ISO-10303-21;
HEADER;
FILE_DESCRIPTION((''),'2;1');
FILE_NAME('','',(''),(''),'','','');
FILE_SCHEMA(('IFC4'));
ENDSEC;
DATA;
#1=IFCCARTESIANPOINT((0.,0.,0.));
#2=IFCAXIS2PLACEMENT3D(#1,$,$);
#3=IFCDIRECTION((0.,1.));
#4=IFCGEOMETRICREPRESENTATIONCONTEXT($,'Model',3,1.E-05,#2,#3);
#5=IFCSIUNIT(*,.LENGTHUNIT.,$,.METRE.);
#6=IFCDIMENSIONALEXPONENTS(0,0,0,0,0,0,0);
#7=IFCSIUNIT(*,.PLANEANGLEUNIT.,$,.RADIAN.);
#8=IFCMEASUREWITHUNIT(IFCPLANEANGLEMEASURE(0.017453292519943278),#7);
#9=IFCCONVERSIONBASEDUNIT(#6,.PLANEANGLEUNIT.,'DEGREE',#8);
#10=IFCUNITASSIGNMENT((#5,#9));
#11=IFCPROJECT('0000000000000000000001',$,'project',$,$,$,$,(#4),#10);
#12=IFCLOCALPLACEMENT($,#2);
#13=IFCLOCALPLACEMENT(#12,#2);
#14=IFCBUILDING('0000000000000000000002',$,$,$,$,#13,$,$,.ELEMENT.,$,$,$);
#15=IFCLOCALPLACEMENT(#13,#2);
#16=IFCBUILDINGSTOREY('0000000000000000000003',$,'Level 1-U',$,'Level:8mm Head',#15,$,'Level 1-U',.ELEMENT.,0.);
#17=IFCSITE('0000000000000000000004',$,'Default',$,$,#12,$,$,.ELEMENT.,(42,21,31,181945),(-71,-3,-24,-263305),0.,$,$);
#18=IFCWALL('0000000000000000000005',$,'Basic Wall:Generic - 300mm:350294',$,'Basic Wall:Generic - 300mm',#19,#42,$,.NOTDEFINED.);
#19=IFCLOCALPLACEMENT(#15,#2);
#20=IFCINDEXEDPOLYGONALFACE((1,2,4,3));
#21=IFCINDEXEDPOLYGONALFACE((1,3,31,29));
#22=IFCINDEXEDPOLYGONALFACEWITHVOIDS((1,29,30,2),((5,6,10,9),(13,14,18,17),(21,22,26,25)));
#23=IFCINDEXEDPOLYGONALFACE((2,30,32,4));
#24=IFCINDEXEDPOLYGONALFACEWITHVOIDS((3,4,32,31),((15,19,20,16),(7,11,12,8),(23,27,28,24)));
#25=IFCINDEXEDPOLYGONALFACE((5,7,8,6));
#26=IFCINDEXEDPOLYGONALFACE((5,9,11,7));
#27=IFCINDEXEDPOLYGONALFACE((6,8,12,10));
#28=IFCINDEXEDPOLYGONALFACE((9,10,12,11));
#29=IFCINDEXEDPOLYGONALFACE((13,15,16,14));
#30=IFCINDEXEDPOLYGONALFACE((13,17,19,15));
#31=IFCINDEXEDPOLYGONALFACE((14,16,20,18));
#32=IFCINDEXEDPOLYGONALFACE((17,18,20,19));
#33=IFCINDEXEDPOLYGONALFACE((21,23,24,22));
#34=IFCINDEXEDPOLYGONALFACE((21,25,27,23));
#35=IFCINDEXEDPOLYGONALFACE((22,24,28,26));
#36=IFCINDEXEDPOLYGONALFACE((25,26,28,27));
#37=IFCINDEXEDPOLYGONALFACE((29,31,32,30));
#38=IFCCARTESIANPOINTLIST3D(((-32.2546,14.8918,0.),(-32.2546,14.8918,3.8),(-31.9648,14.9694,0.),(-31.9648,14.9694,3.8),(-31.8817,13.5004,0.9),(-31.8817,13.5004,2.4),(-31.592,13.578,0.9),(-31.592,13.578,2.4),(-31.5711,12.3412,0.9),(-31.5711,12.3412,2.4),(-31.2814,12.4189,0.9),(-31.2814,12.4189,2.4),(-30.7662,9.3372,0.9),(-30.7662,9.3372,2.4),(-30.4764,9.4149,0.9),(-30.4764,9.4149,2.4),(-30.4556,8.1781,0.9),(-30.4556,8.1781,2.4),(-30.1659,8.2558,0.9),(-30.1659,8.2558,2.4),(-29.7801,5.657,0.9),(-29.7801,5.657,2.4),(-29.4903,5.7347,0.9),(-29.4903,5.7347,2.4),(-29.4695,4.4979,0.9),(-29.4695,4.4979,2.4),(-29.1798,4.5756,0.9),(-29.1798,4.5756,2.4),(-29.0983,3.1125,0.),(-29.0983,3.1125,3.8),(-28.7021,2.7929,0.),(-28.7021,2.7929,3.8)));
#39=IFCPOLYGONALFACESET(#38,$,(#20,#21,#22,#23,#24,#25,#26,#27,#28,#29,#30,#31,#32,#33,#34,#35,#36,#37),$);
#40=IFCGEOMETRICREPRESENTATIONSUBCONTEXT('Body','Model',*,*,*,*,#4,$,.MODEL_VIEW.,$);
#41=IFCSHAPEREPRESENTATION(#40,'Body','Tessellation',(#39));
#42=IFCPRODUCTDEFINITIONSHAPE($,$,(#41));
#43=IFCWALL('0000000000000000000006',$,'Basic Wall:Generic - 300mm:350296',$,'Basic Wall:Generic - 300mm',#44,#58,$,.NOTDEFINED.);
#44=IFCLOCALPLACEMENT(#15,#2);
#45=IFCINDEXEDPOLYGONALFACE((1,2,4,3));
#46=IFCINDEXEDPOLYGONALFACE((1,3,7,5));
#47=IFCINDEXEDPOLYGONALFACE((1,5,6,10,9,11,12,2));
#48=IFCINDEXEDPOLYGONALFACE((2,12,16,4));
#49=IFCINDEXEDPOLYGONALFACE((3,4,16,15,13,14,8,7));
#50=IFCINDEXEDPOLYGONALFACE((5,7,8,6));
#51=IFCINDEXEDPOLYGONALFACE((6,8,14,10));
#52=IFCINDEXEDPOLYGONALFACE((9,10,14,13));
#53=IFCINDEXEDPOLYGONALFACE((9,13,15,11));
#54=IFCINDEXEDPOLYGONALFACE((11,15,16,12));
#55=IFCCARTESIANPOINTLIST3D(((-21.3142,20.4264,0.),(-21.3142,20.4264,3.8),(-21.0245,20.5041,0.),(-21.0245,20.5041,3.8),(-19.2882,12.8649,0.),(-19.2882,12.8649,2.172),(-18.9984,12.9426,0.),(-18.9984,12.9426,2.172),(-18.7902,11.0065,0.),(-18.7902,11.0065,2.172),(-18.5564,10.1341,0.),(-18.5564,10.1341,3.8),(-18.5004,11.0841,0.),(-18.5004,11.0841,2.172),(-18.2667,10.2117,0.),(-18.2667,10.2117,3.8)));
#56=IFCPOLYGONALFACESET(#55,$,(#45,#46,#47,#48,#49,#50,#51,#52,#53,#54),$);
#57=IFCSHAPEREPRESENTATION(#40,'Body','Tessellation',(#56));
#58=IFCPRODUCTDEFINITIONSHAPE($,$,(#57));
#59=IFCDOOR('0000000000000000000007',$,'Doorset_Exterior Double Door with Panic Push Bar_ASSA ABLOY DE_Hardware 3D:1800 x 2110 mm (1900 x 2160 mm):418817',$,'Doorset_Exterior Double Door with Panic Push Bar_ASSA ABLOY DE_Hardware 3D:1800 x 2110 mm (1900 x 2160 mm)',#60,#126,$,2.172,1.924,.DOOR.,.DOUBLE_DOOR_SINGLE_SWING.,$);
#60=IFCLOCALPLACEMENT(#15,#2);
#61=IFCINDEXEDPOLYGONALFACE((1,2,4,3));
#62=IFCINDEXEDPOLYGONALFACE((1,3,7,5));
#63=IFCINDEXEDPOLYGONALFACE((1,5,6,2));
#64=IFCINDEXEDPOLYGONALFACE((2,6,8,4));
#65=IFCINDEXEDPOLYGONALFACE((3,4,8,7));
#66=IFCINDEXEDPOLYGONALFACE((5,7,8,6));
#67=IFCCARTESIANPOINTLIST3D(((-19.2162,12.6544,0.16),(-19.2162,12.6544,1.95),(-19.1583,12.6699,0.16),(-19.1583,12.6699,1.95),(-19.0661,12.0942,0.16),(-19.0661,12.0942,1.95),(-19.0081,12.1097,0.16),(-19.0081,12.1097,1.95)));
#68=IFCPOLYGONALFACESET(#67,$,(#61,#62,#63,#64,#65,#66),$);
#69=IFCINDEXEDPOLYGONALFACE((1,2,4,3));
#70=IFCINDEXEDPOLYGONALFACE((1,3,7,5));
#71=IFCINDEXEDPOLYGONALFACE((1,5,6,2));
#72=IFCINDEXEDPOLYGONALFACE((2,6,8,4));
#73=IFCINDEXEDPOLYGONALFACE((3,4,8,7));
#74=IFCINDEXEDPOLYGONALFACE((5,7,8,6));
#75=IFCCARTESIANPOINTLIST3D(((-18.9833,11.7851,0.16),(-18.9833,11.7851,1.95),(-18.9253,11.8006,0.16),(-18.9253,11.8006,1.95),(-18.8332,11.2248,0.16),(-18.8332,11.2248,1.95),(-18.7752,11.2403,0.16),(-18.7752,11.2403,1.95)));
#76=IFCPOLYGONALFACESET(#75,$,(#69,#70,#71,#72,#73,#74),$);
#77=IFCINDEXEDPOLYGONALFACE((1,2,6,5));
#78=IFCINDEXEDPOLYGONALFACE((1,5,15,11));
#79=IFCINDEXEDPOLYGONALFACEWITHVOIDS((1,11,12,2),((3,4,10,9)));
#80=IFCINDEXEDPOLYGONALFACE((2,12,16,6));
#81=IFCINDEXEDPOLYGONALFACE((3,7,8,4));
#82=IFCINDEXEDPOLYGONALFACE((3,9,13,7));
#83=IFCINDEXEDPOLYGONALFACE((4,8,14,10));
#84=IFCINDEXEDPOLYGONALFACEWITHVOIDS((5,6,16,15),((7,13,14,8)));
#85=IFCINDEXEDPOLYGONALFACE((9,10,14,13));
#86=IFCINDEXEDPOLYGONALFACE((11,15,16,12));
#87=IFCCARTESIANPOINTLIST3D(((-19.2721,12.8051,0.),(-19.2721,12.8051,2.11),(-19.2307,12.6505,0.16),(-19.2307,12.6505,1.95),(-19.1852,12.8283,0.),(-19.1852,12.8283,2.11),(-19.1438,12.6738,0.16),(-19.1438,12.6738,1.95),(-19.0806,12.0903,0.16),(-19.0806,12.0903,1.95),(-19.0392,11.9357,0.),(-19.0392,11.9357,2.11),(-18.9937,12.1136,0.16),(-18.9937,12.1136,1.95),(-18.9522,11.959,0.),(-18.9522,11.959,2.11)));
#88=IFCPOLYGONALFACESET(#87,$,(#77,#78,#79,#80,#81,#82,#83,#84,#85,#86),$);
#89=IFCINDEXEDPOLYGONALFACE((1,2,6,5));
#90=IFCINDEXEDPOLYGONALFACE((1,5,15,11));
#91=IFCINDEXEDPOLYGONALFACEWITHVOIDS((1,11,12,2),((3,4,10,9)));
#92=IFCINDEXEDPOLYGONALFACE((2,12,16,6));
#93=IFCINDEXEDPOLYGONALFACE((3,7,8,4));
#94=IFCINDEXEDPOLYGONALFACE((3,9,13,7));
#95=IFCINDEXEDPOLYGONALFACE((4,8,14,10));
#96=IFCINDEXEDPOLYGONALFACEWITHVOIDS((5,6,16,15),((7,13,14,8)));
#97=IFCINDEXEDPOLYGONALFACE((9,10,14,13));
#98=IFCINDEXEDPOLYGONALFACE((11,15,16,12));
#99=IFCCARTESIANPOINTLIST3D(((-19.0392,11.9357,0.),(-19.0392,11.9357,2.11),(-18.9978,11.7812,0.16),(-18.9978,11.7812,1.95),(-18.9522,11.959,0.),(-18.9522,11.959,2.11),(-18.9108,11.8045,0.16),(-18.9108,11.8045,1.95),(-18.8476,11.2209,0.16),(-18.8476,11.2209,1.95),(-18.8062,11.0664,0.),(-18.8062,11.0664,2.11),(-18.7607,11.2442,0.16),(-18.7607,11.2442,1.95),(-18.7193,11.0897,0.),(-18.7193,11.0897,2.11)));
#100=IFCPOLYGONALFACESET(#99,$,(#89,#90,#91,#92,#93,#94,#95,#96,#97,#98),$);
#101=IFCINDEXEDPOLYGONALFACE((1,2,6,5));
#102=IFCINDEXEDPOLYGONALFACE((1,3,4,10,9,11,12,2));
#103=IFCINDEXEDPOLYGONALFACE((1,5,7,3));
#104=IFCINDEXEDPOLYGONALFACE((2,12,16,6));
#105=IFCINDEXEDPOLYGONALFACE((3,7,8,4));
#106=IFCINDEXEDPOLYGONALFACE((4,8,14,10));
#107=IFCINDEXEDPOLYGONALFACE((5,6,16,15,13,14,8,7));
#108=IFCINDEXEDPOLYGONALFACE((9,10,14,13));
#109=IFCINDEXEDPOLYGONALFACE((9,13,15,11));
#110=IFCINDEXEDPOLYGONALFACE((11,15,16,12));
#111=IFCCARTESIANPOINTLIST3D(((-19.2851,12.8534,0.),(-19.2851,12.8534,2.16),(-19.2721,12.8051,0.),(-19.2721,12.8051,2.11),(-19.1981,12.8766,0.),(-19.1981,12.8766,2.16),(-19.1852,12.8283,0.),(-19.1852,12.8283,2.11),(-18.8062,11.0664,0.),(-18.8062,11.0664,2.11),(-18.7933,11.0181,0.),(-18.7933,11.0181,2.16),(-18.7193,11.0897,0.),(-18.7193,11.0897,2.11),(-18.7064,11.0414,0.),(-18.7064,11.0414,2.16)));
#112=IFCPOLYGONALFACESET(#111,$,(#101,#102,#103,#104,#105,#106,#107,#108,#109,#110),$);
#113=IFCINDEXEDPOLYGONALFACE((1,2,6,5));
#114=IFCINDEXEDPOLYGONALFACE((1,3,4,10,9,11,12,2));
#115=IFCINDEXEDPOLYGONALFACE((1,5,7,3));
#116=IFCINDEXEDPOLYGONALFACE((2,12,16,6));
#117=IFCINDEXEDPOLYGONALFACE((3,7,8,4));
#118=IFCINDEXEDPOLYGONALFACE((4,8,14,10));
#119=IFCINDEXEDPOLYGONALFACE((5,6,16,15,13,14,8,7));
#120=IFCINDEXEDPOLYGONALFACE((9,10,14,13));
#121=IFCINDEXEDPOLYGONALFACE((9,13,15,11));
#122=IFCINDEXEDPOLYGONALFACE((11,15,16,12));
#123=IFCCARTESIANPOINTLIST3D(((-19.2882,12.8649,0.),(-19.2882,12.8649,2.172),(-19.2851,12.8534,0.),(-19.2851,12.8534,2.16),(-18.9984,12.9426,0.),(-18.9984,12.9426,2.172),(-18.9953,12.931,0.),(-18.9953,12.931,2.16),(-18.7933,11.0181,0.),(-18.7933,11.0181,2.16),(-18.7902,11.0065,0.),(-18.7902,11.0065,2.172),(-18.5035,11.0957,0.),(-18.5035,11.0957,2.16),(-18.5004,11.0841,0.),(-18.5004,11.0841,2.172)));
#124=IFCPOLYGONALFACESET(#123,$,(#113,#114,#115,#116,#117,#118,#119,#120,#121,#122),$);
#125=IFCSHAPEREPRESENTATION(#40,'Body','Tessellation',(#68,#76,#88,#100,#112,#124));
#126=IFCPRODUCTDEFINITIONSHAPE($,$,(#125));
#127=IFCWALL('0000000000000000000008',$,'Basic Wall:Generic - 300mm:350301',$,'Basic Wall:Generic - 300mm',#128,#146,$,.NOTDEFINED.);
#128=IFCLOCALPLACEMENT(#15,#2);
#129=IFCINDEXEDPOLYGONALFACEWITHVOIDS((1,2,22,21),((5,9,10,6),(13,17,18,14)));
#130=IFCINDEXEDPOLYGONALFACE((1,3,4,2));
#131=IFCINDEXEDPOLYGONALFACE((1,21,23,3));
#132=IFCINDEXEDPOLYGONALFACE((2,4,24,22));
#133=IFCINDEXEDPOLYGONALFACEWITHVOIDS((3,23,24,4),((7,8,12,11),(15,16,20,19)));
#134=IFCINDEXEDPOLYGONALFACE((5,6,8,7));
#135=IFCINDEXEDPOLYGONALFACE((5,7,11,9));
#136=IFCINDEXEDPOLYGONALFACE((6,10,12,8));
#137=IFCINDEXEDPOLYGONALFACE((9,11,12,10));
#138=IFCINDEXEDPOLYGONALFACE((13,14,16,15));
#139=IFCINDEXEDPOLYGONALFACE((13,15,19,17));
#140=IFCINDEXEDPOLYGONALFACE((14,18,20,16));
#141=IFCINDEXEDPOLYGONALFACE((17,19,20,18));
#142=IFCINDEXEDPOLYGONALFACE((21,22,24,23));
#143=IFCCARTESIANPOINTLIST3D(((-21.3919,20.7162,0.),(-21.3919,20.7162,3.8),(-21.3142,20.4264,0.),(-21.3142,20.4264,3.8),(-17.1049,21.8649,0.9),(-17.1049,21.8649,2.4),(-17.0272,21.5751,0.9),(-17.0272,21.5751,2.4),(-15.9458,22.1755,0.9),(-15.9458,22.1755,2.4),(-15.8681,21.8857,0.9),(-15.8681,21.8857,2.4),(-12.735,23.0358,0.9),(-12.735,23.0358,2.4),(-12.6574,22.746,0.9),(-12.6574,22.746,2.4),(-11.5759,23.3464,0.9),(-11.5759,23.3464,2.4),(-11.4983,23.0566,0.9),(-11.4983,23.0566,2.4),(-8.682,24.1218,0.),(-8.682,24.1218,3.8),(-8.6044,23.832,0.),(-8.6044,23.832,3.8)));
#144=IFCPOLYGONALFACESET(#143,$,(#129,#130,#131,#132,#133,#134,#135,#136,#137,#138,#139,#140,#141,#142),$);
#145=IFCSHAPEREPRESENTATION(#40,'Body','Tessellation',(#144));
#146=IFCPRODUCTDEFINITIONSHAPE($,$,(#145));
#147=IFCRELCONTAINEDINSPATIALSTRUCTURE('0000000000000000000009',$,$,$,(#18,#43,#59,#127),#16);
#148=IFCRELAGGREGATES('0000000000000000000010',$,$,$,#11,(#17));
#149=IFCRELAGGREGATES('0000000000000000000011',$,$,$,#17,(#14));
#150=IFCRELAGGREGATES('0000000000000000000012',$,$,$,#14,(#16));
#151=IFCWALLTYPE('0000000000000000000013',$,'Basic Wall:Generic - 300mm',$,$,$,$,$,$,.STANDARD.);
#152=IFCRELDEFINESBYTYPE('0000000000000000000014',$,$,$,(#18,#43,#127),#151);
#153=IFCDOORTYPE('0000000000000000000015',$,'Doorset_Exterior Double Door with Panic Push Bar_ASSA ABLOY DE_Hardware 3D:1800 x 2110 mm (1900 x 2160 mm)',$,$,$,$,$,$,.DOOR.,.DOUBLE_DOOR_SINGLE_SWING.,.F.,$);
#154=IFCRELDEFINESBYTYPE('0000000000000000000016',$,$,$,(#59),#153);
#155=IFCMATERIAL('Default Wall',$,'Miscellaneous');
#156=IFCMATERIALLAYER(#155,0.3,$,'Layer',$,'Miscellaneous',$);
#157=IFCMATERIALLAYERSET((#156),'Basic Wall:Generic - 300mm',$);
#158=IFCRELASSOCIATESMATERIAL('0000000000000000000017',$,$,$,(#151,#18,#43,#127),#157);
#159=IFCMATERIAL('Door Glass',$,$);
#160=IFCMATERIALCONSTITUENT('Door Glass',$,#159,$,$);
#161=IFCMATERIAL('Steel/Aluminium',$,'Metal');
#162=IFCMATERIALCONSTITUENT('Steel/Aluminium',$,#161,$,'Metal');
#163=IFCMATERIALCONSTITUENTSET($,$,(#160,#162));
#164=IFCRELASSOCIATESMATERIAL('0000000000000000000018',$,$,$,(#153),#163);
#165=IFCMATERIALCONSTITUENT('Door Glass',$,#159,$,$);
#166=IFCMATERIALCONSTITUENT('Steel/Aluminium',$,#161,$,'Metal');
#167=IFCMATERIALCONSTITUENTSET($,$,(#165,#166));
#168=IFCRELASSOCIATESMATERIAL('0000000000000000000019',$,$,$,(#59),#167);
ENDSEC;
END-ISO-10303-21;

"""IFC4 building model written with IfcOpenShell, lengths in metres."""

from ifc_helpers import new_model, entity, si_unit, converted_unit, direction, frame, frame_2d, origin, origin_2d_with_axis, place, context, subcontext, project, spatial, polyline, rectangle, outline, extrude, source, transform, mapped, material, layer, layer_set, layer_usage, constituent, constituent_set, type_object, type_shapes, element, fill, save


model = new_model("IFC4")

# Units and contexts
model_context = context("Model", 3, precision=1e-05, world=origin(), true_north=direction((0.0, 1.0)))
body_context = subcontext(model_context, "Body", "Model", "MODEL_VIEW")
ifc_project = project(units=[si_unit("LENGTHUNIT", "METRE"), converted_unit("PLANEANGLEUNIT", "DEGREE", entity("IfcPlaneAngleMeasure", 0.017453292519943278), si_unit("PLANEANGLEUNIT", "RADIAN"), dimensions=[0, 0, 0, 0, 0, 0, 0])], contexts=[model_context])

# Site, building, storey
site_placement = place(None, origin())
site = spatial("IfcSite", under=ifc_project, at=site_placement, Name="Default", CompositionType="ELEMENT", RefLatitude=(42, 21, 31, 181945), RefLongitude=(-71, -3, -24, -263305), RefElevation=0.0)
building_placement = place(site_placement, origin())
building = spatial("IfcBuilding", under=site, at=building_placement, CompositionType="ELEMENT")
storey_placement = place(building_placement, origin())
storey = spatial("IfcBuildingStorey", under=building, at=storey_placement, Name="Level 1-U", ObjectType="Level:8mm Head", LongName="Level 1-U", CompositionType="ELEMENT", Elevation=0.0)

# Wall, openings
ifc_material_1 = material(Name="Default Wall", Category="Miscellaneous")
ifc_layer_1 = layer(ifc_material_1, 0.3, Name="Layer", Category="Miscellaneous")
ifc_layer_set_1 = layer_set([ifc_layer_1], Name="Basic Wall:Generic - 300mm")
ifc_layer_usage_1 = layer_usage(ifc_layer_set_1, "AXIS2", "NEGATIVE", 0.15)
wall_type_1 = type_object("IfcWallType", Name="Basic Wall:Generic - 300mm", PredefinedType="STANDARD", material=ifc_layer_set_1)
wall_1_placement = place(storey_placement, frame((-32.1097, 14.9306, 0.0), z_axis=(0.0, 0.0, 1.0), x_axis=(0.258819, -0.965926, 0.0)))
wall_1 = element("IfcWall", 1, at=wall_1_placement, inside=storey, type_object=wall_type_1, material=ifc_layer_usage_1, Name="Basic Wall:Generic - 300mm:350294", ObjectType="Basic Wall:Generic - 300mm", PredefinedType="NOTDEFINED", context=body_context, shape_type="SweptSolid", body=[
    extrude(outline(polyline([(12.1948, -0.15), (12.606, 0.15), (12.097, 0.15), (0.0, 0.15), (0.0, -0.15), (12.1948, -0.15)])), origin(), (0.0, 0.0, 1.0), 3.8),
])
opening_1_placement = place(wall_1_placement, frame((10.7605, 0.15, 0.9)))
element("IfcOpeningElement", 2, at=opening_1_placement, cuts=wall_1, PredefinedType="OPENING", context=body_context, shape_type="SweptSolid", body=[
    extrude(rectangle(XDim=1.5, YDim=1.2, at=frame_2d((0.75, 0.6), x_axis=(-1.0, 0.0))), frame((0.0, 0.0, 0.0), z_axis=(0.0, -1.0, 0.0), x_axis=(0.0, 0.0, 1.0)), (0.0, 0.0, 1.0), 0.3),
])
opening_2_placement = place(wall_1_placement, frame((6.9505, 0.15, 0.9)))
element("IfcOpeningElement", 3, at=opening_2_placement, cuts=wall_1, PredefinedType="OPENING", context=body_context, shape_type="SweptSolid", body=[
    extrude(rectangle(XDim=1.5, YDim=1.2, at=frame_2d((0.75, 0.6), x_axis=(-1.0, 0.0))), frame((0.0, 0.0, 0.0), z_axis=(0.0, -1.0, 0.0), x_axis=(0.0, 0.0, 1.0)), (0.0, 0.0, 1.0), 0.3),
])
opening_3_placement = place(wall_1_placement, frame((2.6405, 0.15, 0.9)))
element("IfcOpeningElement", 4, at=opening_3_placement, cuts=wall_1, PredefinedType="OPENING", context=body_context, shape_type="SweptSolid", body=[
    extrude(rectangle(XDim=1.5, YDim=1.2, at=frame_2d((0.75, 0.6), x_axis=(-1.0, 0.0))), frame((0.0, 0.0, 0.0), z_axis=(0.0, -1.0, 0.0), x_axis=(0.0, 0.0, 1.0)), (0.0, 0.0, 1.0), 0.3),
])

# Wall, opening, door
wall_2_placement = place(storey_placement, frame((-18.4115, 10.1729, 0.0), z_axis=(0.0, 0.0, 1.0), x_axis=(-0.258819, 0.965926, 0.0)))
wall_2 = element("IfcWall", 5, at=wall_2_placement, inside=storey, type_object=wall_type_1, material=ifc_layer_usage_1, Name="Basic Wall:Generic - 300mm:350296", ObjectType="Basic Wall:Generic - 300mm", PredefinedType="NOTDEFINED", context=body_context, shape_type="SweptSolid", body=[
    extrude(rectangle(XDim=10.6554, YDim=0.3, at=frame_2d((5.3277, 0.0), x_axis=(-1.0, 0.0))), origin(), (0.0, 0.0, 1.0), 3.8),
])
opening_4_placement = place(wall_2_placement, frame((0.9032, -0.15, 0.0)))
opening_4 = element("IfcOpeningElement", 6, at=opening_4_placement, cuts=wall_2, PredefinedType="OPENING", context=body_context, shape_type="SweptSolid", body=[
    extrude(rectangle(XDim=2.172, YDim=1.924, at=frame_2d((1.086, 0.962), x_axis=(-1.0, 0.0))), frame((0.0, 0.0, 0.0), z_axis=(0.0, 1.0, 0.0), x_axis=(0.0, 0.0, 1.0)), (0.0, 0.0, 1.0), 0.3),
])
ifc_material_2 = material(Name="Door Glass")
ifc_constituent_1 = constituent(ifc_material_2, Name="Door Glass")
ifc_material_3 = material(Name="Steel/Aluminium", Category="Metal")
ifc_constituent_2 = constituent(ifc_material_3, Name="Steel/Aluminium", Category="Metal")
ifc_constituent_set_1 = constituent_set(constituents=[ifc_constituent_1, ifc_constituent_2])
ifc_constituent_3 = constituent(ifc_material_2, Name="Door Glass")
ifc_constituent_4 = constituent(ifc_material_3, Name="Steel/Aluminium", Category="Metal")
ifc_constituent_set_2 = constituent_set(constituents=[ifc_constituent_3, ifc_constituent_4])
door_type_1 = type_object("IfcDoorType", Name="Doorset_Exterior Double Door with Panic Push Bar_ASSA ABLOY DE_Hardware 3D:1800 x 2110 mm (1900 x 2160 mm)", OperationType="DOUBLE_DOOR_SINGLE_SWING", ParameterTakesPrecedence=False, PredefinedType="DOOR", material=ifc_constituent_set_2)
shared_shape_1 = source(origin(), body_context, "Body", "SweptSolid", [
    extrude(rectangle(XDim=0.58, YDim=0.06, at=frame_2d((0.0, 0.0), x_axis=(1.0, 0.0))), frame((1.412, 0.255, 0.16)), (0.0, 0.0, 1.0), 1.79),
    extrude(rectangle(XDim=0.58, YDim=0.06, at=origin_2d_with_axis()), frame((0.512, 0.255, 0.16)), (0.0, 0.0, 1.0), 1.79),
    extrude(outline(polyline([(-0.45, -1.055), (0.45, -1.055), (0.45, 1.055), (-0.45, 1.055), (-0.45, -1.055)]), holes=[polyline([(0.29, -0.895), (-0.29, -0.895), (-0.29, 0.895), (0.29, 0.895), (0.29, -0.895)])]), frame((1.412, 0.3, 1.055), z_axis=(0.0, -1.0, 0.0), x_axis=(1.0, 0.0, 0.0)), (0.0, 0.0, 1.0), 0.09),
    extrude(outline(polyline([(-1.055, -0.45), (1.055, -0.45), (1.055, 0.45), (-1.055, 0.45), (-1.055, -0.45)]), holes=[polyline([(-0.895, -0.29), (-0.895, 0.29), (0.895, 0.29), (0.895, -0.29), (-0.895, -0.29)])]), frame((0.512, 0.3, 1.055), z_axis=(0.0, -1.0, 0.0), x_axis=(0.0, 0.0, -1.0)), (0.0, 0.0, 1.0), 0.09),
    extrude(outline(polyline([(-1.0925, -0.95), (1.0675, -0.95), (1.0675, -0.9), (-1.0425, -0.9), (-1.0425, 0.9), (1.0675, 0.9), (1.0675, 0.95), (-1.0925, 0.95), (-1.0925, -0.95)])), frame((0.962, 0.3, 1.0675), z_axis=(0.0, -1.0, 0.0), x_axis=(0.0, 0.0, -1.0)), (0.0, 0.0, 1.0), 0.09),
    extrude(outline(polyline([(-0.962, -1.089), (0.962, -1.089), (0.962, 1.083), (0.95, 1.083), (0.95, -1.077), (-0.95, -1.077), (-0.95, 1.083), (-0.962, 1.083), (-0.962, -1.089)])), frame((0.962, 0.3, 1.083), z_axis=(0.0, -1.0, 0.0), x_axis=(-1.0, 0.0, 0.0)), (0.0, 0.0, 1.0), 0.3),
])
type_shapes(door_type_1, [shared_shape_1])
door_1_placement = place(opening_4_placement, origin())
door_1 = element("IfcDoor", 7, at=door_1_placement, inside=storey, type_object=door_type_1, material=ifc_constituent_set_1, Name="Doorset_Exterior Double Door with Panic Push Bar_ASSA ABLOY DE_Hardware 3D:1800 x 2110 mm (1900 x 2160 mm):418817", ObjectType="Doorset_Exterior Double Door with Panic Push Bar_ASSA ABLOY DE_Hardware 3D:1800 x 2110 mm (1900 x 2160 mm)", OperationType="DOUBLE_DOOR_SINGLE_SWING", OverallHeight=2.172, OverallWidth=1.924, PredefinedType="DOOR", context=body_context, shape_type="MappedRepresentation", body=[
    mapped(shared_shape_1, transform((0.0, 0.0, 0.0), scale=1.0)),
])
fill(opening_4, door_1)

# Wall, openings
wall_3_placement = place(storey_placement, frame((-21.3531, 20.5713, 0.0), z_axis=(0.0, 0.0, 1.0), x_axis=(0.965926, 0.258819, 0.0)))
wall_3 = element("IfcWall", 8, at=wall_3_placement, inside=storey, type_object=wall_type_1, material=ifc_layer_usage_1, Name="Basic Wall:Generic - 300mm:350301", ObjectType="Basic Wall:Generic - 300mm", PredefinedType="NOTDEFINED", context=body_context, shape_type="SweptSolid", body=[
    extrude(rectangle(XDim=13.1583, YDim=0.3, at=frame_2d((6.5791, 0.0), x_axis=(-1.0, 0.0))), origin(), (0.0, 0.0, 1.0), 3.8),
])
opening_5_placement = place(wall_3_placement, frame((4.4383, -0.15, 0.9)))
element("IfcOpeningElement", 9, at=opening_5_placement, cuts=wall_3, PredefinedType="OPENING", context=body_context, shape_type="SweptSolid", body=[
    extrude(rectangle(XDim=1.5, YDim=1.2, at=frame_2d((0.75, 0.6), x_axis=(-1.0, 0.0))), frame((0.0, 0.0, 0.0), z_axis=(0.0, 1.0, 0.0), x_axis=(0.0, 0.0, 1.0)), (0.0, 0.0, 1.0), 0.3),
])
opening_6_placement = place(wall_3_placement, frame((8.9622, -0.15, 0.9)))
element("IfcOpeningElement", 10, at=opening_6_placement, cuts=wall_3, PredefinedType="OPENING", context=body_context, shape_type="SweptSolid", body=[
    extrude(rectangle(XDim=1.5, YDim=1.2, at=frame_2d((0.75, 0.6), x_axis=(-1.0, 0.0))), frame((0.0, 0.0, 0.0), z_axis=(0.0, 1.0, 0.0), x_axis=(0.0, 0.0, 1.0)), (0.0, 0.0, 1.0), 0.3),
])

save(model, "model.ifc")
